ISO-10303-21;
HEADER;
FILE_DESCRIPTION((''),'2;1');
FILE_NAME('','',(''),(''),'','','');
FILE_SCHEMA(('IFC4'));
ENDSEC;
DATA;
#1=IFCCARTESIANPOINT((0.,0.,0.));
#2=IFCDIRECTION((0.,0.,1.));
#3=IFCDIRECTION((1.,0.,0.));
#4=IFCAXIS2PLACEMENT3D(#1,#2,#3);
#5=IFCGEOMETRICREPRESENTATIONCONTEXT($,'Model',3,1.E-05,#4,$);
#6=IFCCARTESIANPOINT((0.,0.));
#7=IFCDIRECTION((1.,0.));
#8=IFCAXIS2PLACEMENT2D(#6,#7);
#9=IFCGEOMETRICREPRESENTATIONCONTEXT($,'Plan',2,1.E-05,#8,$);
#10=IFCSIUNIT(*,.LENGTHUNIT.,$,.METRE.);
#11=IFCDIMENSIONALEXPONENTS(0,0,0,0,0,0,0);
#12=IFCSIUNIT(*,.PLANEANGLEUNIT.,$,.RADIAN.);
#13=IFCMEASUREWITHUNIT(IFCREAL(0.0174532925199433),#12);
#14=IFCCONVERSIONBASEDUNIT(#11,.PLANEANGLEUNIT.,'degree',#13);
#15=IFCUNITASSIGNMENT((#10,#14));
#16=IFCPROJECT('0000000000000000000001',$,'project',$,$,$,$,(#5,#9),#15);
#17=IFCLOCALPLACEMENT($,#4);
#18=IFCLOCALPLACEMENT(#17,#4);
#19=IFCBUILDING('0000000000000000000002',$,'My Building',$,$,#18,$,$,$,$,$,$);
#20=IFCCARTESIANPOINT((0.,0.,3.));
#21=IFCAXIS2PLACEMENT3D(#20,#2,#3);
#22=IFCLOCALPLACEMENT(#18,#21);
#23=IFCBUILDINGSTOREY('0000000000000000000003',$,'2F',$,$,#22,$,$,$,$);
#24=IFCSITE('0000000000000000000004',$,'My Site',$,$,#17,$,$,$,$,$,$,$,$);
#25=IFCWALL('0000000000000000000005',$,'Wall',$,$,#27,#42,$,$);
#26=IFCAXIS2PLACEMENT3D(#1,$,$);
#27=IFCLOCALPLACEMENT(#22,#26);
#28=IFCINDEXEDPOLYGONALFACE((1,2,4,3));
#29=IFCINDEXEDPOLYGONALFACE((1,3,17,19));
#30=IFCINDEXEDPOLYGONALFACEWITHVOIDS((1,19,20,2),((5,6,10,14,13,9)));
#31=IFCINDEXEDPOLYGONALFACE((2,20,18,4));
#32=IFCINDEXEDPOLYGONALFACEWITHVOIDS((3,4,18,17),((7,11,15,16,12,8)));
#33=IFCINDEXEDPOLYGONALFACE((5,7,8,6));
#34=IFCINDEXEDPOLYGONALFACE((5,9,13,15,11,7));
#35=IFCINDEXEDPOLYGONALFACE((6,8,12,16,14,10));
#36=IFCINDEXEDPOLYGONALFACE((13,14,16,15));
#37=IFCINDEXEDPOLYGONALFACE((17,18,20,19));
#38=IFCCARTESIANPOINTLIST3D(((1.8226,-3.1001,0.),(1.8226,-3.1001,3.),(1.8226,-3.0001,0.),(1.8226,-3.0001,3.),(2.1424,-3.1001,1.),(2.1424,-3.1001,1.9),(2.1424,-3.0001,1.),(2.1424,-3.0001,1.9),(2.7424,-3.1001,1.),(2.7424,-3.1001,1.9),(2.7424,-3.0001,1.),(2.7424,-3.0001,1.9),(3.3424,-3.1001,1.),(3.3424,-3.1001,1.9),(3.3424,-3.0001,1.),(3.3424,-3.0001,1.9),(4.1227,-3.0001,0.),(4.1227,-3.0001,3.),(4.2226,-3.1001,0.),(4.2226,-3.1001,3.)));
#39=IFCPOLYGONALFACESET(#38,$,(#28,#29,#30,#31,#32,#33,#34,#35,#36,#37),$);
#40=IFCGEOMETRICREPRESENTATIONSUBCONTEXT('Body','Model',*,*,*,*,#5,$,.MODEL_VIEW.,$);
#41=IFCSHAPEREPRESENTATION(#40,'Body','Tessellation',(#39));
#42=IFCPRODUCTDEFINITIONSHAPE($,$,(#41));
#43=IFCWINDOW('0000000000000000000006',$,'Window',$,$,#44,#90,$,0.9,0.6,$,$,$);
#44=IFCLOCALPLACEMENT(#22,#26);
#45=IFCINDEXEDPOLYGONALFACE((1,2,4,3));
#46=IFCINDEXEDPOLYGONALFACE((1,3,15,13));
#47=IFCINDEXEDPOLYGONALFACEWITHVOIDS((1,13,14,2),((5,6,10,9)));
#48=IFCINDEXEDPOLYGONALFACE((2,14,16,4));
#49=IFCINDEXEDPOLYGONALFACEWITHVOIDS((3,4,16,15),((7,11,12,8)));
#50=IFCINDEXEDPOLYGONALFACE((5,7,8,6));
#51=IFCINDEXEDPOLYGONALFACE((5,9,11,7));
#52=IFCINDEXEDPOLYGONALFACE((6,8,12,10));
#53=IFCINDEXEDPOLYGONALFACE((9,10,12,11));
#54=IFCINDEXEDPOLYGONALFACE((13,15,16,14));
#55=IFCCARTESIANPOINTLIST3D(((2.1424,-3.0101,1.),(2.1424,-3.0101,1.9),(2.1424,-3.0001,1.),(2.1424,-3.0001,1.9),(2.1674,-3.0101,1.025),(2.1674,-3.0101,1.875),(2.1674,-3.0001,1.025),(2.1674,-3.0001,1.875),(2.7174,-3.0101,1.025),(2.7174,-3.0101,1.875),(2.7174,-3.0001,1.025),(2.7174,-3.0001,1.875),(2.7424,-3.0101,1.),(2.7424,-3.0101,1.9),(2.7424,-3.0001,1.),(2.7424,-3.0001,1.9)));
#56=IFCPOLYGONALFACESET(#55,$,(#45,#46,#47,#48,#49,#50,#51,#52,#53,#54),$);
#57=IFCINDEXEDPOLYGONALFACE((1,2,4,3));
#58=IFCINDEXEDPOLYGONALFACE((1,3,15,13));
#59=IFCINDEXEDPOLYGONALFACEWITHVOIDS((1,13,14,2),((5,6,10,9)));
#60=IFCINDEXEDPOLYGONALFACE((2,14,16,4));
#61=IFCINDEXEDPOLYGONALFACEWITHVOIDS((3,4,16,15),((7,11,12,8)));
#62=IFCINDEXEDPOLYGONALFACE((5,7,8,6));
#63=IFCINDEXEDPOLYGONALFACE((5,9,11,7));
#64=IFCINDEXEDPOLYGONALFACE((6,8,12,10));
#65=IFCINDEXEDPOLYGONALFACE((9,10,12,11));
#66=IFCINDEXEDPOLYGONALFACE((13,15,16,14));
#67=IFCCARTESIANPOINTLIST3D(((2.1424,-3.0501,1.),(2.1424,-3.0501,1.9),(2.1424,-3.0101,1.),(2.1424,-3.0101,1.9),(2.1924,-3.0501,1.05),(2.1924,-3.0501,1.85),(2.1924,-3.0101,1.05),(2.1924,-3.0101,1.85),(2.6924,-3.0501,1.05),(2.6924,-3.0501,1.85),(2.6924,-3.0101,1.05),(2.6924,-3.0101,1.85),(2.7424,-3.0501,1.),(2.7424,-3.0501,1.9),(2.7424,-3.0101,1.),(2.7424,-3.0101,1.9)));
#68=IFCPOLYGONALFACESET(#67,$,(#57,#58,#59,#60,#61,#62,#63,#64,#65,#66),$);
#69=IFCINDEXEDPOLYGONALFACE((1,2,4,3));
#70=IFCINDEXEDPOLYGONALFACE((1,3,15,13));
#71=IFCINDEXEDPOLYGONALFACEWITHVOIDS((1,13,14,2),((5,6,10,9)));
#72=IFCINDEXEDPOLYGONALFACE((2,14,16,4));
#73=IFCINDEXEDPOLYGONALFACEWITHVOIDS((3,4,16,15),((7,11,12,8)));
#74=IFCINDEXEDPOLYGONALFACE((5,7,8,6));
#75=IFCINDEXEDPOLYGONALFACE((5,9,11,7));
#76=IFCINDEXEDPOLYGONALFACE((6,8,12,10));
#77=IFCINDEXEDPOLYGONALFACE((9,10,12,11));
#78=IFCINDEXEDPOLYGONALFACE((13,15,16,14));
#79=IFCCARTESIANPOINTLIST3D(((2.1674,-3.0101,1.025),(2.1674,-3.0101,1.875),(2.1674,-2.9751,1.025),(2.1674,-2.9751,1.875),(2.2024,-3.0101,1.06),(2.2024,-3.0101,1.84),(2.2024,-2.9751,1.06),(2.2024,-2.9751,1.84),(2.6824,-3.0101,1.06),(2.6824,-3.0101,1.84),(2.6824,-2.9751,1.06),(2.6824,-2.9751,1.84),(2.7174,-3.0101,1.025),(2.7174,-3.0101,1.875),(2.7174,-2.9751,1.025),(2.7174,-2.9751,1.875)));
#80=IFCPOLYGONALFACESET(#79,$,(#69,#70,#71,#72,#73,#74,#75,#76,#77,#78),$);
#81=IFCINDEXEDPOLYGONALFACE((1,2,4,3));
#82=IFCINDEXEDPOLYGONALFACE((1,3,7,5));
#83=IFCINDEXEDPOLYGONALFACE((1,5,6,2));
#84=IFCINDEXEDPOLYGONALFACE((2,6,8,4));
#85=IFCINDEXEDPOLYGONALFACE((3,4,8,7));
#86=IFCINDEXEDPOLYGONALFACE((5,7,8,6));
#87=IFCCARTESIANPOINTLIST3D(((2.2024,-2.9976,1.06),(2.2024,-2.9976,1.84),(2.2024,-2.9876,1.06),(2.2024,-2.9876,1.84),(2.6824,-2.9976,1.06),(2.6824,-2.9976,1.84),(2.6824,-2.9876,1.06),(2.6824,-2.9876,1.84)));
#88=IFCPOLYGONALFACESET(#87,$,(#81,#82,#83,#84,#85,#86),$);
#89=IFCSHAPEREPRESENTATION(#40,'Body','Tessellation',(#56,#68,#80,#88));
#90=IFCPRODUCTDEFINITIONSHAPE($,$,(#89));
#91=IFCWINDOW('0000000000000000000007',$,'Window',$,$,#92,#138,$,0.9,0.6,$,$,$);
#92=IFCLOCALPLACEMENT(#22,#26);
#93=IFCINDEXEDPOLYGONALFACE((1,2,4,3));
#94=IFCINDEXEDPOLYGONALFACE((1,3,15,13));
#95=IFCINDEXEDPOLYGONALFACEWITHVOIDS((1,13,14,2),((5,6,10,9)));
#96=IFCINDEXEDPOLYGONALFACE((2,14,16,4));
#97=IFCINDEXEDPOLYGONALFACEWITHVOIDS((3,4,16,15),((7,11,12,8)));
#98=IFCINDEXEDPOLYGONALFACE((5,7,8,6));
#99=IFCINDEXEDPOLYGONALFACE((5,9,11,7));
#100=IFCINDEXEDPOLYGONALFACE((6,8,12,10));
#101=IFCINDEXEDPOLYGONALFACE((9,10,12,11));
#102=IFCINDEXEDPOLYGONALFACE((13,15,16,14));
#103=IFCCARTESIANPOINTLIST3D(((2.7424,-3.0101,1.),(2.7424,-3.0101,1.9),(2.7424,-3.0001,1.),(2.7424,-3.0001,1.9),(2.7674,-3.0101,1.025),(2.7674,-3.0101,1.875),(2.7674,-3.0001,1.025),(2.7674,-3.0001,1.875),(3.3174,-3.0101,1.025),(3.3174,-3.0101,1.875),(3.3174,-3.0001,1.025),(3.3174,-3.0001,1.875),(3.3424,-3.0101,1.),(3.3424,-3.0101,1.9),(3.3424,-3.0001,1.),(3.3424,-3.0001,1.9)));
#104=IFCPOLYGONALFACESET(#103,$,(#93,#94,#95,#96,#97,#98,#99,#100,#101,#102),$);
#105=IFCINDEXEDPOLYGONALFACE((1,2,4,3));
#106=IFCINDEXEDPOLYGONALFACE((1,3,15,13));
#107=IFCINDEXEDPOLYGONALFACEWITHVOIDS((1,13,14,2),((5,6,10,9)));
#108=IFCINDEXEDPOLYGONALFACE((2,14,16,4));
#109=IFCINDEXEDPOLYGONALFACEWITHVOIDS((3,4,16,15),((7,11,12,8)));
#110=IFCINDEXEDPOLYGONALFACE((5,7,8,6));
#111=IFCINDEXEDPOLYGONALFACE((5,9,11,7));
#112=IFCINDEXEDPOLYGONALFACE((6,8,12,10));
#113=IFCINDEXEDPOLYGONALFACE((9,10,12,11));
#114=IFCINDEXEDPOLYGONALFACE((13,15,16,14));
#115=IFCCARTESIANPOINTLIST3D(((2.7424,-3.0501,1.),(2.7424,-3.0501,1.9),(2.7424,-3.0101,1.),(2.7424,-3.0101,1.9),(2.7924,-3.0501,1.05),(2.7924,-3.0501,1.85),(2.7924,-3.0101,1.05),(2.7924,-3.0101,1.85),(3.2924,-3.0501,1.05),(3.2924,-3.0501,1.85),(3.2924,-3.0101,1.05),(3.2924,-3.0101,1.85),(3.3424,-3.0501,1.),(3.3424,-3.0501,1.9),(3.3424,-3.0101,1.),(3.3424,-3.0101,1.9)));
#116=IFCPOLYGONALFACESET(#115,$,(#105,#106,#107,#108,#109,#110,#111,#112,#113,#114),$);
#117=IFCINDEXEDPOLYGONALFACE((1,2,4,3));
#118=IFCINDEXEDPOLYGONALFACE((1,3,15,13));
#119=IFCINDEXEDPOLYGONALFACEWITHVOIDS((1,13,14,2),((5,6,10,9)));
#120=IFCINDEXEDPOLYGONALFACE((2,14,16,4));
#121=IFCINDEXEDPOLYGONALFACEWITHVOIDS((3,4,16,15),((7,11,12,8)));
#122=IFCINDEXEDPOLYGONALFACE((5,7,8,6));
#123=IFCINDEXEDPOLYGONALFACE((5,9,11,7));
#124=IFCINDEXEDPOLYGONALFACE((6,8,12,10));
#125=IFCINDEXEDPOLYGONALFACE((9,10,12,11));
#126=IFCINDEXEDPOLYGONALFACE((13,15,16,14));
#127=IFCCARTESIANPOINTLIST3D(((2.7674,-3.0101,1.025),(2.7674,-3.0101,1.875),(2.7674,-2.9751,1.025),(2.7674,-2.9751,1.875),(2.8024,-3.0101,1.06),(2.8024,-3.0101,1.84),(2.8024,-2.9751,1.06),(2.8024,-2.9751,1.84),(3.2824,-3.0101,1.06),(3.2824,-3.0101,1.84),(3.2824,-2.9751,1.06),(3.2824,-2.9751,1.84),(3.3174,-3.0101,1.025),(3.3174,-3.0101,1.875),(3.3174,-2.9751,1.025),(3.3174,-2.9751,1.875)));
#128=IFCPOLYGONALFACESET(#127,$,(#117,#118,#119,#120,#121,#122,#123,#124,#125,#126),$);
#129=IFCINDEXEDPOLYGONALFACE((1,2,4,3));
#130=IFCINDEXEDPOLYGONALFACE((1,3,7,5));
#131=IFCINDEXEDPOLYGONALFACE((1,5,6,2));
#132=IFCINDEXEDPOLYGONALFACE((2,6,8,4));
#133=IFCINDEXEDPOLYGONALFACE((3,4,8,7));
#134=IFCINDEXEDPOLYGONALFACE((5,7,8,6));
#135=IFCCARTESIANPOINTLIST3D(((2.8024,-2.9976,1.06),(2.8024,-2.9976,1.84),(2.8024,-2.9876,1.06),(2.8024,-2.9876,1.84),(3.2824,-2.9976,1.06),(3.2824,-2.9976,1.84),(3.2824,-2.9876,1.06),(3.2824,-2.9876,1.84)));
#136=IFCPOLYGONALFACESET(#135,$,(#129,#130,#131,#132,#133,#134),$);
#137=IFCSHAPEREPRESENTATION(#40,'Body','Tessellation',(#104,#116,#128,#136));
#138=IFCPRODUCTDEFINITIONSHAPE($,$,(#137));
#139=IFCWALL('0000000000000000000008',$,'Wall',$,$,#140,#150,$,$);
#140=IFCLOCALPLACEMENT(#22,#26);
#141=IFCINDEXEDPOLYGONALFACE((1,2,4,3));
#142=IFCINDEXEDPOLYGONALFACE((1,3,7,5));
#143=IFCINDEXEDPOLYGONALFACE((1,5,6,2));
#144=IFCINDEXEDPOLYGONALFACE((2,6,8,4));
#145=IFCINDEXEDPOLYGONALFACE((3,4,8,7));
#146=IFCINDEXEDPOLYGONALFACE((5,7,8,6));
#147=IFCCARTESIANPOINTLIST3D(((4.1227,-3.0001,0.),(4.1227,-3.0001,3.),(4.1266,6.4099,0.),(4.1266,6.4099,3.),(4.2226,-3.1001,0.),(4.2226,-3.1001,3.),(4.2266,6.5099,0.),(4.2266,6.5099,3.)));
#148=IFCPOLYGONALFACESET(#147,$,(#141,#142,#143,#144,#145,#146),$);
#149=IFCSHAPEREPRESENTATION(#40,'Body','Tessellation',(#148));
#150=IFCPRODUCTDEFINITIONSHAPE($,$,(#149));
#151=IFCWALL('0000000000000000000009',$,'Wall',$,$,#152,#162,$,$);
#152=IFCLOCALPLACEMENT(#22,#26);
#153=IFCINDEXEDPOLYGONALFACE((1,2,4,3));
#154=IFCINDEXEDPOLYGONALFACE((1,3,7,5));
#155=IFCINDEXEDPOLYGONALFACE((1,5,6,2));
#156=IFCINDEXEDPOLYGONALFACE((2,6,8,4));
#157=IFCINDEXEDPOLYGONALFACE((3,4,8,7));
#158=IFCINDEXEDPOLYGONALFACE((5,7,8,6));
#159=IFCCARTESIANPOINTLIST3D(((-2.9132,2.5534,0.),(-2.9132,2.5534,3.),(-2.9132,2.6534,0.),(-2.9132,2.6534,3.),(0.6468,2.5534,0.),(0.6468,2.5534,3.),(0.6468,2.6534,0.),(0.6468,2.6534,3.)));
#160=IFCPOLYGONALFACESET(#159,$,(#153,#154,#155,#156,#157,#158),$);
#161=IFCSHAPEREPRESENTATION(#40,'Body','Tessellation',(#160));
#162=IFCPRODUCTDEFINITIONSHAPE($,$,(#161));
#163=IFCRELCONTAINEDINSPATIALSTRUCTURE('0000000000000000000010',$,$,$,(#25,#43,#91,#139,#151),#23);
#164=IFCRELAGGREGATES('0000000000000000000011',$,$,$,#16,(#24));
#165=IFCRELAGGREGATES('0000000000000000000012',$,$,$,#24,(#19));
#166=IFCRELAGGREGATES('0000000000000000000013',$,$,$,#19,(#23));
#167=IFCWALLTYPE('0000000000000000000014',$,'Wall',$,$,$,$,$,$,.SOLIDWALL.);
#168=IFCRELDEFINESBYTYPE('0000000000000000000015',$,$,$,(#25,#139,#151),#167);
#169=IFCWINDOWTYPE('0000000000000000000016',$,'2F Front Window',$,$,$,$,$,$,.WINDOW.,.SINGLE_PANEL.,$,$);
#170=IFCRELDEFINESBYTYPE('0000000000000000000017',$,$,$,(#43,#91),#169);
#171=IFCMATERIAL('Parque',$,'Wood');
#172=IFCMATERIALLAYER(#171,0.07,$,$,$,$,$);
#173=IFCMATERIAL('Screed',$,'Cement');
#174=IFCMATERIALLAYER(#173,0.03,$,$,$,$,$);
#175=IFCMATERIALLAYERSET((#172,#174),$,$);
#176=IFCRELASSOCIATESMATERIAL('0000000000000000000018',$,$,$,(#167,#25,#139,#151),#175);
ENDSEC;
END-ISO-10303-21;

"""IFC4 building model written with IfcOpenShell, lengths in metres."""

from ifc_helpers import new_model, entity, si_unit, converted_unit, frame, origin_with_axes, origin_2d_with_axis, place, context, subcontext, project, spatial, line, indexed_curve, outline, extrude, shape, source, transform, mapped, material, layer, layer_set, layer_usage, type_object, type_shapes, element, fill, save


model = new_model("IFC4")

# Units and contexts
model_context = context("Model", 3, precision=1e-05, world=origin_with_axes())
plan_context = context("Plan", 2, precision=1e-05, world=origin_2d_with_axis())
body_context_1 = subcontext(model_context, "Body", "Model", "MODEL_VIEW")
body_context_2 = subcontext(plan_context, "Body", "Plan", "PLAN_VIEW")
ifc_project = project(units=[si_unit("LENGTHUNIT", "METRE"), converted_unit("PLANEANGLEUNIT", "degree", entity("IfcReal", 0.0174532925199433), si_unit("PLANEANGLEUNIT", "RADIAN"), dimensions=[0, 0, 0, 0, 0, 0, 0])], contexts=[model_context, plan_context])

# Site, building, storey
site_placement = place(None, origin_with_axes())
site = spatial("IfcSite", under=ifc_project, at=site_placement, Name="My Site")
building_placement = place(site_placement, origin_with_axes())
building = spatial("IfcBuilding", under=site, at=building_placement, Name="My Building")
storey_placement = place(building_placement, frame((0.0, 0.0, 3.0), z_axis=(0.0, 0.0, 1.0), x_axis=(1.0, 0.0, 0.0)))
storey = spatial("IfcBuildingStorey", under=building, at=storey_placement, Name="2F")

# Wall, openings, windows
ifc_material_1 = material(Name="Parque", Category="Wood")
ifc_layer_1 = layer(ifc_material_1, 0.07)
ifc_material_2 = material(Name="Screed", Category="Cement")
ifc_layer_2 = layer(ifc_material_2, 0.03)
ifc_layer_set_1 = layer_set([ifc_layer_1, ifc_layer_2])
ifc_layer_usage_1 = layer_usage(ifc_layer_set_1, "AXIS2", "POSITIVE", 0.0)
wall_type = type_object("IfcWallType", Name="Wall", PredefinedType="SOLIDWALL", material=ifc_layer_set_1)
wall_1_placement = place(storey_placement, frame((1.8226, -3.1001, 0.0), z_axis=(0.0, 0.0, 1.0), x_axis=(1.0, 0.0, 0.0)))
wall_1 = element("IfcWall", 1, at=wall_1_placement, inside=storey, type_object=wall_type, material=ifc_layer_usage_1, Name="Wall", context=body_context_1, shape_type="SweptSolid", body=[
    extrude(outline(indexed_curve([(0.0, 0.0), (0.0, 0.1), (2.3, 0.1), (2.4, 0.0)], segments=[line(1, 2, 3, 4, 1)])), origin_with_axes(), (0.0, 0.0, 1.0), 3.0),
])
shared_shape_1 = source(origin_with_axes(), body_context_1, "Body", "SweptSolid", [
    extrude(outline(indexed_curve([(0.0, 0.0), (0.6, 0.0), (0.6, 0.9), (0.0, 0.9)], segments=[line(1, 2, 3, 4, 1)])), frame((0.0, -0.6, 0.0), z_axis=(0.0, -1.0, 0.0), x_axis=(1.0, 0.0, 0.0)), (0.0, 0.0, -1.0), 1.2),
])
opening_1_placement = place(wall_1_placement, frame((0.3197, 0.0, 1.0), z_axis=(0.0, 0.0, 1.0), x_axis=(1.0, 0.0, 0.0)))
opening_1 = element("IfcOpeningElement", 2, at=opening_1_placement, cuts=wall_1, PredefinedType="OPENING", context=body_context_1, shape_type="MappedRepresentation", body=[
    mapped(shared_shape_1, transform((0.0, 0.0, 0.0), x_axis=(1.0, 0.0, 0.0), y_axis=(0.0, 1.0, 0.0), z_axis=(0.0, 0.0, 1.0), scale=1.0)),
])
opening_2_placement = place(wall_1_placement, frame((0.9197, 0.0, 1.0), z_axis=(0.0, 0.0, 1.0), x_axis=(1.0, 0.0, 0.0)))
opening_2 = element("IfcOpeningElement", 3, at=opening_2_placement, cuts=wall_1, PredefinedType="OPENING", context=body_context_1, shape_type="MappedRepresentation", body=[
    mapped(shared_shape_1, transform((0.0, 0.0, 0.0), x_axis=(1.0, 0.0, 0.0), y_axis=(0.0, 1.0, 0.0), z_axis=(0.0, 0.0, 1.0), scale=1.0)),
])
window_type = type_object("IfcWindowType", Name="2F Front Window", PartitioningType="SINGLE_PANEL", PredefinedType="WINDOW")
shared_shape_2 = source(origin_with_axes(), body_context_1, "Body", "SweptSolid", [
    extrude(outline(indexed_curve([(0.0, 0.0), (0.6, 0.0), (0.6, 0.9), (0.0, 0.9)], segments=[line(1, 2, 3, 4, 1)]), holes=[indexed_curve([(0.025, 0.025), (0.575, 0.025), (0.575, 0.875), (0.025, 0.875)], segments=[line(1, 2, 3, 4, 1)])]), frame((0.0, 0.09, 0.0), z_axis=(0.0, -1.0, 0.0), x_axis=(1.0, 0.0, 0.0)), (0.0, 0.0, -1.0), 0.01),
    extrude(outline(indexed_curve([(0.0, 0.0), (0.6, 0.0), (0.6, 0.9), (0.0, 0.9)], segments=[line(1, 2, 3, 4, 1)]), holes=[indexed_curve([(0.05, 0.05), (0.55, 0.05), (0.55, 0.85), (0.05, 0.85)], segments=[line(1, 2, 3, 4, 1)])]), frame((0.0, 0.05, 0.0), z_axis=(0.0, -1.0, 0.0), x_axis=(1.0, 0.0, 0.0)), (0.0, 0.0, -1.0), 0.04),
    extrude(outline(indexed_curve([(0.0, 0.0), (0.55, 0.0), (0.55, 0.85), (0.0, 0.85)], segments=[line(1, 2, 3, 4, 1)]), holes=[indexed_curve([(0.035, 0.035), (0.515, 0.035), (0.515, 0.815), (0.035, 0.815)], segments=[line(1, 2, 3, 4, 1)])]), frame((0.025, 0.09, 0.025), z_axis=(0.0, -1.0, 0.0), x_axis=(1.0, 0.0, 0.0)), (0.0, 0.0, -1.0), 0.035),
    extrude(outline(indexed_curve([(0.035, 0.035), (0.515, 0.035), (0.515, 0.815), (0.035, 0.815)], segments=[line(1, 2, 3, 4, 1)])), frame((0.025, 0.1025, 0.025), z_axis=(0.0, -1.0, 0.0), x_axis=(1.0, 0.0, 0.0)), (0.0, 0.0, -1.0), 0.01),
])
shared_shape_3 = source(origin_with_axes(), body_context_2, "Body", "Curve2D", [
    entity("IfcIndexedPolyCurve", entity("IfcCartesianPointList2D", [[0.05, 0.05], [0.55, 0.05]])),
    entity("IfcIndexedPolyCurve", entity("IfcCartesianPointList2D", [[0.0, 0.1], [0.025, 0.1], [0.025, 0.09], [0.05, 0.09], [0.05, 0.05], [0.0, 0.05]]), [entity("IfcLineIndex", [1, 2, 3, 4, 5, 6, 1])]),
    entity("IfcIndexedPolyCurve", entity("IfcCartesianPointList2D", [[0.6, 0.1], [0.575, 0.1], [0.575, 0.09], [0.55, 0.09], [0.55, 0.05], [0.6, 0.05]]), [entity("IfcLineIndex", [1, 2, 3, 4, 5, 6, 1])]),
    entity("IfcIndexedPolyCurve", entity("IfcCartesianPointList2D", [[0.025, 0.09], [0.06, 0.09], [0.06, 0.125], [0.025, 0.125]]), [entity("IfcLineIndex", [1, 2, 3, 4, 1])]),
    entity("IfcIndexedPolyCurve", entity("IfcCartesianPointList2D", [[0.575, 0.09], [0.54, 0.09], [0.54, 0.125], [0.575, 0.125]]), [entity("IfcLineIndex", [1, 2, 3, 4, 1])]),
    entity("IfcIndexedPolyCurve", entity("IfcCartesianPointList2D", [[0.06, 0.09], [0.54, 0.09]])),
    entity("IfcIndexedPolyCurve", entity("IfcCartesianPointList2D", [[0.06, 0.125], [0.54, 0.125]])),
    entity("IfcIndexedPolyCurve", entity("IfcCartesianPointList2D", [[0.06, 0.1075], [0.54, 0.1075]])),
])
type_shapes(window_type, [shared_shape_2, shared_shape_3])
window_1_placement = place(opening_1_placement, origin_with_axes())
window_1 = element("IfcWindow", 4, at=window_1_placement, inside=storey, type_object=window_type, Name="Window", OverallHeight=0.9, OverallWidth=0.6, shapes=[
    shape(body_context_1, "Body", "MappedRepresentation", [mapped(shared_shape_2, transform((0.0, 0.0, 0.0), x_axis=(1.0, 0.0, 0.0), y_axis=(0.0, 1.0, 0.0), z_axis=(0.0, 0.0, 1.0), scale=1.0))]),
    shape(body_context_2, "Body", "MappedRepresentation", [mapped(shared_shape_3, transform((0.0, 0.0, 0.0), x_axis=(1.0, 0.0, 0.0), y_axis=(0.0, 1.0, 0.0), z_axis=(0.0, 0.0, 1.0), scale=1.0))]),
])
fill(opening_1, window_1)
window_2_placement = place(opening_2_placement, origin_with_axes())
window_2 = element("IfcWindow", 5, at=window_2_placement, inside=storey, type_object=window_type, Name="Window", OverallHeight=0.9, OverallWidth=0.6, shapes=[
    shape(body_context_1, "Body", "MappedRepresentation", [mapped(shared_shape_2, transform((0.0, 0.0, 0.0), x_axis=(1.0, 0.0, 0.0), y_axis=(0.0, 1.0, 0.0), z_axis=(0.0, 0.0, 1.0), scale=1.0))]),
    shape(body_context_2, "Body", "MappedRepresentation", [mapped(shared_shape_3, transform((0.0, 0.0, 0.0), x_axis=(1.0, 0.0, 0.0), y_axis=(0.0, 1.0, 0.0), z_axis=(0.0, 0.0, 1.0), scale=1.0))]),
])
fill(opening_2, window_2)

# Walls
ifc_layer_usage_2 = layer_usage(ifc_layer_set_1, "AXIS2", "POSITIVE", 0.0)
wall_2_placement = place(storey_placement, frame((4.2226, -3.1001, 0.0), z_axis=(0.0, 0.0, 1.0), x_axis=(0.000415, 1.0, 0.0)))
element("IfcWall", 6, at=wall_2_placement, inside=storey, type_object=wall_type, material=ifc_layer_usage_2, Name="Wall", context=body_context_1, shape_type="SweptSolid", body=[
    extrude(outline(indexed_curve([(0.0, 0.0), (0.1, 0.1), (9.51, 0.1), (9.61, 0.0)], segments=[line(1, 2, 3, 4, 1)])), origin_with_axes(), (0.0, 0.0, 1.0), 3.0),
])
ifc_layer_usage_3 = layer_usage(ifc_layer_set_1, "AXIS2", "POSITIVE", 0.0)
wall_3_placement = place(storey_placement, frame((-2.9132, 2.5534, 0.0), z_axis=(0.0, 0.0, 1.0), x_axis=(1.0, 0.0, 0.0)))
element("IfcWall", 7, at=wall_3_placement, inside=storey, type_object=wall_type, material=ifc_layer_usage_3, Name="Wall", context=body_context_1, shape_type="SweptSolid", body=[
    extrude(outline(indexed_curve([(0.0, 0.0), (0.0, 0.1), (3.56, 0.1), (3.56, 0.0)], segments=[line(1, 2, 3, 4, 1)])), origin_with_axes(), (0.0, 0.0, 1.0), 3.0),
])

save(model, "model.ifc")
